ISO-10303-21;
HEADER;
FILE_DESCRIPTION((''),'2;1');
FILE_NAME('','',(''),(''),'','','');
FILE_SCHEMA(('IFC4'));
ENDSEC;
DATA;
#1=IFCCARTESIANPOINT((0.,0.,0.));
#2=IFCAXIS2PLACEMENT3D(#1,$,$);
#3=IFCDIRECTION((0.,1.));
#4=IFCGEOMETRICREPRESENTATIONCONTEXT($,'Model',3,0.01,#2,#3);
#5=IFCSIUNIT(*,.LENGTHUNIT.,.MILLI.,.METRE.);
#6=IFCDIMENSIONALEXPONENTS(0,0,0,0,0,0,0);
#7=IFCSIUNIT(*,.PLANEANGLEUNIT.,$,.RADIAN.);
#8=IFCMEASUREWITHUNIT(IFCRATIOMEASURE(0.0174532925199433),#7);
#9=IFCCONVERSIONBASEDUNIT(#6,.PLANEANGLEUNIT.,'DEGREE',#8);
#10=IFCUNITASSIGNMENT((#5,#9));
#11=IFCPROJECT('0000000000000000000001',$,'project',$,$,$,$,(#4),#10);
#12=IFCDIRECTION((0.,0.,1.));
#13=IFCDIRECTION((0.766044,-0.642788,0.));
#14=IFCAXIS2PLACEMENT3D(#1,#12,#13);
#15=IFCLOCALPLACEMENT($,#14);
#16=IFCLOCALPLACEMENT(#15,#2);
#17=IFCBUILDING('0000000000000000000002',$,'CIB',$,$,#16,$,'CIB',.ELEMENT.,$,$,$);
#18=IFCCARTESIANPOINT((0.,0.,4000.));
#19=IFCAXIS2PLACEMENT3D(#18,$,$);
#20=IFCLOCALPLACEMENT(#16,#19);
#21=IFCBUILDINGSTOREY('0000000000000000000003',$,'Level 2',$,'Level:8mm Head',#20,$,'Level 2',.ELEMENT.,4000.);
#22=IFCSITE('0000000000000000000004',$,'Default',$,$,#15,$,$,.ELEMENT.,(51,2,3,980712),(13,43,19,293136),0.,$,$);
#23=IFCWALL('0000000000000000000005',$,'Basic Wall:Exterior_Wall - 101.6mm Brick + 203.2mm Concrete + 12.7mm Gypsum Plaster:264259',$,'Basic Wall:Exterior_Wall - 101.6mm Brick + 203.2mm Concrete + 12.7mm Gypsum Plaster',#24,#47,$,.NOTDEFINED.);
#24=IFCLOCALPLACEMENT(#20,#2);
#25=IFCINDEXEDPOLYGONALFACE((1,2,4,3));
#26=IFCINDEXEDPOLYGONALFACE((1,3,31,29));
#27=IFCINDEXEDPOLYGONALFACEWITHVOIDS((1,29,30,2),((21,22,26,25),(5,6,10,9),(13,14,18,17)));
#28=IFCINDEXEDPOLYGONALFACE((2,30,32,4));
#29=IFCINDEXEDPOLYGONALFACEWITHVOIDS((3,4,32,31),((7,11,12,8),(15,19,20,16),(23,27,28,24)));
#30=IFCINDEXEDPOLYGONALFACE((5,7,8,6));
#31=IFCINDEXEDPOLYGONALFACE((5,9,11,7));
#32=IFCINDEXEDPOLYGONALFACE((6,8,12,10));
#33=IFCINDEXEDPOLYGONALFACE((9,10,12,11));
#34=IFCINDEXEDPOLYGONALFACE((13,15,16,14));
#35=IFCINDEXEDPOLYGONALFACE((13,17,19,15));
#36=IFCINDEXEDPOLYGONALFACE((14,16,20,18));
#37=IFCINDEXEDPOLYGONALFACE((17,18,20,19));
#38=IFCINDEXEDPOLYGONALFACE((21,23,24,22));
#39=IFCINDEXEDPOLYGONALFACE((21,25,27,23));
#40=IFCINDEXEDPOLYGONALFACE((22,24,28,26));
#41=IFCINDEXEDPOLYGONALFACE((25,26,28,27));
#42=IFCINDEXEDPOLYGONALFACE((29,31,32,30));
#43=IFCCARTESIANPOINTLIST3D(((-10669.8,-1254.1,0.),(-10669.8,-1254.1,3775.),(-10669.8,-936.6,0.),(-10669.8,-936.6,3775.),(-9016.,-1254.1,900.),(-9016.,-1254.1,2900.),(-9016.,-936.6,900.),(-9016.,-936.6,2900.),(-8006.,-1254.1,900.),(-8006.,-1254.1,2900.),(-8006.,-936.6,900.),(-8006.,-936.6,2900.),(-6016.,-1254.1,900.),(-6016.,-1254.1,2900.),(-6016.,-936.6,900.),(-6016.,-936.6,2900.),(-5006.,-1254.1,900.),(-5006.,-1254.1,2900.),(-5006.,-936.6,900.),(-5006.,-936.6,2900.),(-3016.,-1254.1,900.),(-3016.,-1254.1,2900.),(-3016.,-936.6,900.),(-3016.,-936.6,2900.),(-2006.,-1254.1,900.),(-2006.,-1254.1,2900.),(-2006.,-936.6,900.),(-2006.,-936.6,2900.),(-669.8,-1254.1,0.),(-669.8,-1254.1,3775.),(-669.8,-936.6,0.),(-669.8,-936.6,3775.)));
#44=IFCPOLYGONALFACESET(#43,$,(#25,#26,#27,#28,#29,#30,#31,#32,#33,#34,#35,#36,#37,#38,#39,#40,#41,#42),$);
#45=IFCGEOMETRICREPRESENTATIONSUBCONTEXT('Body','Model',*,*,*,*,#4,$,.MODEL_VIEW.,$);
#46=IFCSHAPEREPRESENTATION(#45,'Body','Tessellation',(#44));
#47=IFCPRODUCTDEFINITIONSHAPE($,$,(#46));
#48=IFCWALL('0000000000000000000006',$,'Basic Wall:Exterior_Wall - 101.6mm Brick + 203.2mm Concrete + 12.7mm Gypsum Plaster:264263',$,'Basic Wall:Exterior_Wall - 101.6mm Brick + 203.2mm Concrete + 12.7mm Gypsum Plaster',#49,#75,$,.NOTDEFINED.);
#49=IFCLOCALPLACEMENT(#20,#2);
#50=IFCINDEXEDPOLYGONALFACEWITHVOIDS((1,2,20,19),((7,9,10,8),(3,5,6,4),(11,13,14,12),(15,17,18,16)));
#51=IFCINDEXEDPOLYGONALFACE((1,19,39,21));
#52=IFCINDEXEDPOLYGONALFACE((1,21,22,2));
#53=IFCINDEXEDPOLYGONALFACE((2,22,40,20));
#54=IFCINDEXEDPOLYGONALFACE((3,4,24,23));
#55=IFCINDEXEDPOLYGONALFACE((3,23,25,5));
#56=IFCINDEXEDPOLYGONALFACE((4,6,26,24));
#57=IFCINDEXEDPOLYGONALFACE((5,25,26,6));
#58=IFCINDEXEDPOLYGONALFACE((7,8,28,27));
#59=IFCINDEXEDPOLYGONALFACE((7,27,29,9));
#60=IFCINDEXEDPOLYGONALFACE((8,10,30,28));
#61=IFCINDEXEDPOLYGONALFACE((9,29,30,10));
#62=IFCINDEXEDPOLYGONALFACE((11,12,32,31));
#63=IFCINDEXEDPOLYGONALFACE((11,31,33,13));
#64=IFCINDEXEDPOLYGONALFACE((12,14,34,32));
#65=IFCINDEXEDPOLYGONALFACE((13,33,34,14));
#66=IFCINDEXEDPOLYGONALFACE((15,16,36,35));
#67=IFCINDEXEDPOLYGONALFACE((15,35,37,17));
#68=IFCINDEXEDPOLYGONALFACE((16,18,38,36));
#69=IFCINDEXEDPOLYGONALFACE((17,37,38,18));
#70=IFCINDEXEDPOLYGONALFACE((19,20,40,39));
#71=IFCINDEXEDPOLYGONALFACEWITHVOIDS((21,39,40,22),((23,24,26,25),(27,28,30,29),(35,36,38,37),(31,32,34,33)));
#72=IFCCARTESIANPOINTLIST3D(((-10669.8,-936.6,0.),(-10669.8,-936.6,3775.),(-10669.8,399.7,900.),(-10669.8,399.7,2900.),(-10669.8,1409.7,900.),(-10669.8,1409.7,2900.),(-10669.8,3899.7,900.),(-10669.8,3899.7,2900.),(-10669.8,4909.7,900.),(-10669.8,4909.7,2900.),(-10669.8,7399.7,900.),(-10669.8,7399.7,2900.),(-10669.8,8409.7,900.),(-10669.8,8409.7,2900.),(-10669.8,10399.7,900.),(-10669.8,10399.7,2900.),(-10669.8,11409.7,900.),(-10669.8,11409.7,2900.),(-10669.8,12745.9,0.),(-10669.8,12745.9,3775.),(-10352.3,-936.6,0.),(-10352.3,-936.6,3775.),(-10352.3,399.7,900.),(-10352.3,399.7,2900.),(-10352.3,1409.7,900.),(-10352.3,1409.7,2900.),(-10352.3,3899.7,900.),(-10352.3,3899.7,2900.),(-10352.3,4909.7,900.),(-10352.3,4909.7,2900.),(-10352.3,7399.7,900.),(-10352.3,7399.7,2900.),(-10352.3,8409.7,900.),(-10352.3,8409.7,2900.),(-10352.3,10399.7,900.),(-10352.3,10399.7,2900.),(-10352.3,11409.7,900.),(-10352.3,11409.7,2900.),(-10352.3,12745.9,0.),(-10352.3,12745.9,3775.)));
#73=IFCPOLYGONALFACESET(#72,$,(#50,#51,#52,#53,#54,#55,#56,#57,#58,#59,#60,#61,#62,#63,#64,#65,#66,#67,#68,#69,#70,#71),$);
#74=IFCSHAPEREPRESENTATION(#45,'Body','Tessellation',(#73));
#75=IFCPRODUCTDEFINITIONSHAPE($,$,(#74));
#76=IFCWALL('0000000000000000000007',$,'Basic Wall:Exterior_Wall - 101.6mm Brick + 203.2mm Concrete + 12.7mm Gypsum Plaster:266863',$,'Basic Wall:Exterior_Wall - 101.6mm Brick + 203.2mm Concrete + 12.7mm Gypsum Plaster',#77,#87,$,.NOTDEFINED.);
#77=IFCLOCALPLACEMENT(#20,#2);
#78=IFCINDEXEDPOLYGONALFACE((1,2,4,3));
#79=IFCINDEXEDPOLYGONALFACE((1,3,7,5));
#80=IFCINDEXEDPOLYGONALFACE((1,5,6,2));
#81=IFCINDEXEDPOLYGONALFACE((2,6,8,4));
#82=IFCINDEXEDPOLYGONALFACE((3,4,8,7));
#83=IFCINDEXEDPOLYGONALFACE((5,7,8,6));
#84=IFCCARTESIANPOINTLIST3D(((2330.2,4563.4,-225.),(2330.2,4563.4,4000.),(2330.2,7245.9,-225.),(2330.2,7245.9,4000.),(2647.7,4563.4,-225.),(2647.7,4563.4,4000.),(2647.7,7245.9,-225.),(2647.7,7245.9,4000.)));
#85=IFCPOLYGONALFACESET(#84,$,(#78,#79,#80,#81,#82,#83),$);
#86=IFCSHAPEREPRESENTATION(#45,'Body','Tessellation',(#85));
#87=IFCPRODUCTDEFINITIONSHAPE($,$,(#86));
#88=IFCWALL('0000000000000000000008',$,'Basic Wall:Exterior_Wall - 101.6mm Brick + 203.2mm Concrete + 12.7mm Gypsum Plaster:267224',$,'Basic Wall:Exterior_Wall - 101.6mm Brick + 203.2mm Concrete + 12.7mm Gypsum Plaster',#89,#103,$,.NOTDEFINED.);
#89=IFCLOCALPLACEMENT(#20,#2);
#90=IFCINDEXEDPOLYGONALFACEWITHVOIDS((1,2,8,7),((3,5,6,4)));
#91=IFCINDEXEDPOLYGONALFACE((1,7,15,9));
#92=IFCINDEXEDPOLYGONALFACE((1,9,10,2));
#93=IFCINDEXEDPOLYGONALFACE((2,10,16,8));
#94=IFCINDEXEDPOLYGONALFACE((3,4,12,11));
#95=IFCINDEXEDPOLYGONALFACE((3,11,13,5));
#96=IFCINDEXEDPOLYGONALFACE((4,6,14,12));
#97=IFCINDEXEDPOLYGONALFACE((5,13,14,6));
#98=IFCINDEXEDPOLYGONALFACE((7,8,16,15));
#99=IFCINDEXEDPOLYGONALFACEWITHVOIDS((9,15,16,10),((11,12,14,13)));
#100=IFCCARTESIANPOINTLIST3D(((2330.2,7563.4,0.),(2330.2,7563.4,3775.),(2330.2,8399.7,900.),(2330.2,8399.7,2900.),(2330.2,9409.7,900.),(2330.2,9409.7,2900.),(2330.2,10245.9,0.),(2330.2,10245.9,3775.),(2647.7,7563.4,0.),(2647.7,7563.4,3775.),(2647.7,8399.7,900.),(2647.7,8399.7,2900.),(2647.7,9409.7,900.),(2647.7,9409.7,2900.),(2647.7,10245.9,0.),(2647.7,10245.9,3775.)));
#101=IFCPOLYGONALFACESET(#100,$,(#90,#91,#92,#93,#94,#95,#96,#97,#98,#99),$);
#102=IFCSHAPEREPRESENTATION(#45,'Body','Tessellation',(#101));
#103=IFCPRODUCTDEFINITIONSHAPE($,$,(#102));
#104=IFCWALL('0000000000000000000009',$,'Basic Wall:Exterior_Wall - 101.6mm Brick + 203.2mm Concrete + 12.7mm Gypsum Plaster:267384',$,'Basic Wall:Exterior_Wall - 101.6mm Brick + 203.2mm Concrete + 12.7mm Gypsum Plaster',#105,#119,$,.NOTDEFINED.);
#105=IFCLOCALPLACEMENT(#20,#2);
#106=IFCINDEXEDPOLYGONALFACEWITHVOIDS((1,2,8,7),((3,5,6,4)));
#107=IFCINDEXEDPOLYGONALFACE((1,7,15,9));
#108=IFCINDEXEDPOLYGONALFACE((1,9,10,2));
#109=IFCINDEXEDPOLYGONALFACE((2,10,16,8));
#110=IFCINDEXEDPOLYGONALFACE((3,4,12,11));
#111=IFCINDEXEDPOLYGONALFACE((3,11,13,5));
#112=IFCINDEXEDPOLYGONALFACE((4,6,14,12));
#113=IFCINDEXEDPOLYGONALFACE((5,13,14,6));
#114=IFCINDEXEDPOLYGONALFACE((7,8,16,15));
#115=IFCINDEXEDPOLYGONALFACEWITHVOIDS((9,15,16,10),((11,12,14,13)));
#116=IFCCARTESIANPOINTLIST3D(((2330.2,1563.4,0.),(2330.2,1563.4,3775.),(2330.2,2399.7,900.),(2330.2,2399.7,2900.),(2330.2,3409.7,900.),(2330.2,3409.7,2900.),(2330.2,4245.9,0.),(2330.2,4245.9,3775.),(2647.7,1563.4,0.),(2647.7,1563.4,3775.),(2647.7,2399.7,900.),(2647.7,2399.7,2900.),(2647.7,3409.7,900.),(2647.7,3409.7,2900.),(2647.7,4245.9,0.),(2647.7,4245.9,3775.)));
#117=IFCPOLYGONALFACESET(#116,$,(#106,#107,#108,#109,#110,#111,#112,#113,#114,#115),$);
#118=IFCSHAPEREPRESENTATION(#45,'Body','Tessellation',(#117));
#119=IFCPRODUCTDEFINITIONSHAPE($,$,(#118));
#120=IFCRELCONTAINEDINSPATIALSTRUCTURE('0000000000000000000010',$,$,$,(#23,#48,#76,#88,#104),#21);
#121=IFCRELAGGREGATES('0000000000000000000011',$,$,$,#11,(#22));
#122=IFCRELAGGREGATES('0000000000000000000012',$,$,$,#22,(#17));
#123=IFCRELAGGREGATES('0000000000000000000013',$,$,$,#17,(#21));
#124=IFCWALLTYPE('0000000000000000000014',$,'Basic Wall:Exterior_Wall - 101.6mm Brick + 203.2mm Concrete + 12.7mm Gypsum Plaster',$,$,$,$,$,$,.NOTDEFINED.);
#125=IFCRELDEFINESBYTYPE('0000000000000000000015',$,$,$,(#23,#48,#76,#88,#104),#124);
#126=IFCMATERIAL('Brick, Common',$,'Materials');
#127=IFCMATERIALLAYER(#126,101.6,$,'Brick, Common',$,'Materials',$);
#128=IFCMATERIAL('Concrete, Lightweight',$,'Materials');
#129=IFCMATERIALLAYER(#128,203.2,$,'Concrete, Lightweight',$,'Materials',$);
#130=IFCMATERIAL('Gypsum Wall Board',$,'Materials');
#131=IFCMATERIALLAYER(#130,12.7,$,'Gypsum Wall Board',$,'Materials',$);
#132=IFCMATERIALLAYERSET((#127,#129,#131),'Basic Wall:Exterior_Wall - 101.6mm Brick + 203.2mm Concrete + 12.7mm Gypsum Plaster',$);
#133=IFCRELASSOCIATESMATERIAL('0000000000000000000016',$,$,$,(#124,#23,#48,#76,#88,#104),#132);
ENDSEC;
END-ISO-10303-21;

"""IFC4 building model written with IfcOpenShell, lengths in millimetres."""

from ifc_helpers import new_model, entity, si_unit, converted_unit, direction, frame, frame_2d, origin, place, context, subcontext, project, spatial, polyline, rectangle, extrude, clip, bounded_halfspace, material, layer, layer_set, layer_usage, type_object, element, save


model = new_model("IFC4")

# Units and contexts
model_context = context("Model", 3, precision=0.01, world=origin(), true_north=direction((0.0, 1.0)))
body_context = subcontext(model_context, "Body", "Model", "MODEL_VIEW")
ifc_project = project(units=[si_unit("LENGTHUNIT", "METRE", prefix="MILLI"), converted_unit("PLANEANGLEUNIT", "DEGREE", entity("IfcRatioMeasure", 0.0174532925199433), si_unit("PLANEANGLEUNIT", "RADIAN"), dimensions=[0, 0, 0, 0, 0, 0, 0])], contexts=[model_context])

# Site, building, storey
site_placement = place(None, frame((0.0, 0.0, 0.0), z_axis=(0.0, 0.0, 1.0), x_axis=(0.766044, -0.642788, 0.0)))
site = spatial("IfcSite", under=ifc_project, at=site_placement, Name="Default", CompositionType="ELEMENT", RefLatitude=(51, 2, 3, 980712), RefLongitude=(13, 43, 19, 293136), RefElevation=0.0)
building_placement = place(site_placement, origin())
building = spatial("IfcBuilding", under=site, at=building_placement, Name="CIB", LongName="CIB", CompositionType="ELEMENT")
storey_placement = place(building_placement, frame((0.0, 0.0, 4000.0)))
storey = spatial("IfcBuildingStorey", under=building, at=storey_placement, Name="Level 2", ObjectType="Level:8mm Head", LongName="Level 2", CompositionType="ELEMENT", Elevation=4000.0)

# Shared definitions
ifc_material_1 = material(Name="Brick, Common", Category="Materials")
ifc_layer_1 = layer(ifc_material_1, 101.6, Name="Brick, Common", Category="Materials")
ifc_material_2 = material(Name="Concrete, Lightweight", Category="Materials")
ifc_layer_2 = layer(ifc_material_2, 203.2, Name="Concrete, Lightweight", Category="Materials")
ifc_material_3 = material(Name="Gypsum Wall Board", Category="Materials")
ifc_layer_3 = layer(ifc_material_3, 12.7, Name="Gypsum Wall Board", Category="Materials")
ifc_layer_set_1 = layer_set([ifc_layer_1, ifc_layer_2, ifc_layer_3], Name="Basic Wall:Exterior_Wall - 101.6mm Brick + 203.2mm Concrete + 12.7mm Gypsum Plaster")
wall_type_1 = type_object("IfcWallType", Name="Basic Wall:Exterior_Wall - 101.6mm Brick + 203.2mm Concrete + 12.7mm Gypsum Plaster", PredefinedType="NOTDEFINED", material=ifc_layer_set_1)

# Walls, openings
ifc_layer_usage_1 = layer_usage(ifc_layer_set_1, "AXIS2", "NEGATIVE", 158.8)
wall_1_placement = place(storey_placement, frame((-669.8, -1095.3, 0.0), z_axis=(0.0, 0.0, 1.0), x_axis=(-1.0, 0.0, 0.0)))
wall_1 = element("IfcWall", 1, at=wall_1_placement, inside=storey, type_object=wall_type_1, material=ifc_layer_usage_1, Name="Basic Wall:Exterior_Wall - 101.6mm Brick + 203.2mm Concrete + 12.7mm Gypsum Plaster:264259", ObjectType="Basic Wall:Exterior_Wall - 101.6mm Brick + 203.2mm Concrete + 12.7mm Gypsum Plaster", PredefinedType="NOTDEFINED", context=body_context, shape_type="Clipping", body=[
    clip(extrude(rectangle(XDim=10000.0, YDim=317.5, at=frame_2d((5000.0, 0.0), x_axis=(-1.0, 0.0))), origin(), (0.0, 0.0, 1.0), 3775.0), bounded_halfspace(frame((0.0, -158.8, 3775.0), z_axis=(0.0, 0.0, -1.0), x_axis=(0.0, -1.0, 0.0)), True, frame((0.0, -158.8, 3775.0)), polyline([(0.0, 0.0), (9682.5, 0.0), (10000.0, 0.0), (10000.0, 317.5), (0.0, 317.5), (0.0, 0.0)]))),
])
opening_1_placement = place(wall_1_placement, frame((2346.2, 158.7, 900.0)))
element("IfcOpeningElement", 2, at=opening_1_placement, cuts=wall_1, ObjectType="Opening", PredefinedType="OPENING", context=body_context, shape_type="SweptSolid", body=[
    extrude(rectangle(XDim=2000.0, YDim=1010.0, at=frame_2d((1000.0, 505.0), x_axis=(1.0, 0.0))), frame((0.0, 0.0, 0.0), z_axis=(0.0, -1.0, 0.0), x_axis=(0.0, 0.0, 1.0)), (0.0, 0.0, 1.0), 317.5),
])
opening_2_placement = place(wall_1_placement, frame((8346.2, 158.7, 900.0)))
element("IfcOpeningElement", 3, at=opening_2_placement, cuts=wall_1, ObjectType="Opening", PredefinedType="OPENING", context=body_context, shape_type="SweptSolid", body=[
    extrude(rectangle(XDim=2000.0, YDim=1010.0, at=frame_2d((1000.0, 505.0), x_axis=(1.0, 0.0))), frame((0.0, 0.0, 0.0), z_axis=(0.0, -1.0, 0.0), x_axis=(0.0, 0.0, 1.0)), (0.0, 0.0, 1.0), 317.5),
])
opening_3_placement = place(wall_1_placement, frame((5346.2, 158.7, 900.0)))
element("IfcOpeningElement", 4, at=opening_3_placement, cuts=wall_1, ObjectType="Opening", PredefinedType="OPENING", context=body_context, shape_type="SweptSolid", body=[
    extrude(rectangle(XDim=2000.0, YDim=1010.0, at=frame_2d((1000.0, 505.0), x_axis=(1.0, 0.0))), frame((0.0, 0.0, 0.0), z_axis=(0.0, -1.0, 0.0), x_axis=(0.0, 0.0, 1.0)), (0.0, 0.0, 1.0), 317.5),
])
ifc_layer_usage_2 = layer_usage(ifc_layer_set_1, "AXIS2", "NEGATIVE", 158.8)
wall_2_placement = place(storey_placement, frame((-10511.0, -936.6, 0.0), z_axis=(0.0, 0.0, 1.0), x_axis=(0.0, 1.0, 0.0)))
wall_2 = element("IfcWall", 5, at=wall_2_placement, inside=storey, type_object=wall_type_1, material=ifc_layer_usage_2, Name="Basic Wall:Exterior_Wall - 101.6mm Brick + 203.2mm Concrete + 12.7mm Gypsum Plaster:264263", ObjectType="Basic Wall:Exterior_Wall - 101.6mm Brick + 203.2mm Concrete + 12.7mm Gypsum Plaster", PredefinedType="NOTDEFINED", context=body_context, shape_type="Clipping", body=[
    clip(extrude(rectangle(XDim=13682.5, YDim=317.5, at=frame_2d((6841.2, 0.0), x_axis=(-1.0, 0.0))), origin(), (0.0, 0.0, 1.0), 3775.0), bounded_halfspace(frame((0.0, -158.7, 3775.0), z_axis=(0.0, 0.0, -1.0), x_axis=(1.0, 0.0, 0.0)), True, frame((0.0, -158.7, 3775.0)), polyline([(0.0, 0.0), (13682.5, 0.0), (13682.5, 317.5), (0.0, 317.5), (0.0, 0.0)]))),
])
opening_4_placement = place(wall_2_placement, frame((2346.2, 158.8, 900.0)))
element("IfcOpeningElement", 6, at=opening_4_placement, cuts=wall_2, ObjectType="Opening", PredefinedType="OPENING", context=body_context, shape_type="SweptSolid", body=[
    extrude(rectangle(XDim=2000.0, YDim=1010.0, at=frame_2d((1000.0, 505.0), x_axis=(1.0, 0.0))), frame((0.0, 0.0, 0.0), z_axis=(0.0, -1.0, 0.0), x_axis=(0.0, 0.0, 1.0)), (0.0, 0.0, 1.0), 317.5),
])
opening_5_placement = place(wall_2_placement, frame((12346.2, 158.8, 900.0)))
element("IfcOpeningElement", 7, at=opening_5_placement, cuts=wall_2, ObjectType="Opening", PredefinedType="OPENING", context=body_context, shape_type="SweptSolid", body=[
    extrude(rectangle(XDim=2000.0, YDim=1010.0, at=frame_2d((1000.0, 505.0), x_axis=(1.0, 0.0))), frame((0.0, 0.0, 0.0), z_axis=(0.0, -1.0, 0.0), x_axis=(0.0, 0.0, 1.0)), (0.0, 0.0, 1.0), 317.5),
])
opening_6_placement = place(wall_2_placement, frame((9346.2, 158.8, 900.0)))
element("IfcOpeningElement", 8, at=opening_6_placement, cuts=wall_2, ObjectType="Opening", PredefinedType="OPENING", context=body_context, shape_type="SweptSolid", body=[
    extrude(rectangle(XDim=2000.0, YDim=1010.0, at=frame_2d((1000.0, 505.0), x_axis=(1.0, 0.0))), frame((0.0, 0.0, 0.0), z_axis=(0.0, -1.0, 0.0), x_axis=(0.0, 0.0, 1.0)), (0.0, 0.0, 1.0), 317.5),
])
opening_7_placement = place(wall_2_placement, frame((5846.2, 158.8, 900.0)))
element("IfcOpeningElement", 9, at=opening_7_placement, cuts=wall_2, ObjectType="Opening", PredefinedType="OPENING", context=body_context, shape_type="SweptSolid", body=[
    extrude(rectangle(XDim=2000.0, YDim=1010.0, at=frame_2d((1000.0, 505.0), x_axis=(1.0, 0.0))), frame((0.0, 0.0, 0.0), z_axis=(0.0, -1.0, 0.0), x_axis=(0.0, 0.0, 1.0)), (0.0, 0.0, 1.0), 317.5),
])

# Wall
ifc_layer_usage_3 = layer_usage(ifc_layer_set_1, "AXIS2", "NEGATIVE", 158.8)
wall_3_placement = place(storey_placement, frame((2489.0, 7245.9, -225.0), z_axis=(0.0, 0.0, 1.0), x_axis=(0.0, -1.0, 0.0)))
element("IfcWall", 10, at=wall_3_placement, inside=storey, type_object=wall_type_1, material=ifc_layer_usage_3, Name="Basic Wall:Exterior_Wall - 101.6mm Brick + 203.2mm Concrete + 12.7mm Gypsum Plaster:266863", ObjectType="Basic Wall:Exterior_Wall - 101.6mm Brick + 203.2mm Concrete + 12.7mm Gypsum Plaster", PredefinedType="NOTDEFINED", context=body_context, shape_type="SweptSolid", body=[
    extrude(rectangle(XDim=2682.5, YDim=317.5, at=frame_2d((1341.2, 0.0), x_axis=(-1.0, 0.0))), origin(), (0.0, 0.0, 1.0), 4225.0),
])

# Walls, openings
ifc_layer_usage_4 = layer_usage(ifc_layer_set_1, "AXIS2", "NEGATIVE", 158.8)
wall_4_placement = place(storey_placement, frame((2489.0, 10245.9, 0.0), z_axis=(0.0, 0.0, 1.0), x_axis=(0.0, -1.0, 0.0)))
wall_4 = element("IfcWall", 11, at=wall_4_placement, inside=storey, type_object=wall_type_1, material=ifc_layer_usage_4, Name="Basic Wall:Exterior_Wall - 101.6mm Brick + 203.2mm Concrete + 12.7mm Gypsum Plaster:267224", ObjectType="Basic Wall:Exterior_Wall - 101.6mm Brick + 203.2mm Concrete + 12.7mm Gypsum Plaster", PredefinedType="NOTDEFINED", context=body_context, shape_type="Clipping", body=[
    clip(extrude(rectangle(XDim=2682.5, YDim=317.5, at=frame_2d((1341.2, 0.0), x_axis=(-1.0, 0.0))), origin(), (0.0, 0.0, 1.0), 3775.0), bounded_halfspace(frame((0.0, -158.8, 3775.0), z_axis=(0.0, 0.0, -1.0), x_axis=(-1.0, 0.0, 0.0)), True, frame((0.0, -158.8, 3775.0)), polyline([(0.0, 0.0), (2682.5, 0.0), (2682.5, 317.5), (0.0, 317.5), (0.0, 0.0)]))),
])
opening_8_placement = place(wall_4_placement, frame((1846.2, 158.8, 900.0)))
element("IfcOpeningElement", 12, at=opening_8_placement, cuts=wall_4, ObjectType="Opening", PredefinedType="OPENING", context=body_context, shape_type="SweptSolid", body=[
    extrude(rectangle(XDim=2000.0, YDim=1010.0, at=frame_2d((1000.0, 505.0), x_axis=(1.0, 0.0))), frame((0.0, 0.0, 0.0), z_axis=(0.0, -1.0, 0.0), x_axis=(0.0, 0.0, 1.0)), (0.0, 0.0, 1.0), 317.5),
])
ifc_layer_usage_5 = layer_usage(ifc_layer_set_1, "AXIS2", "POSITIVE", -158.8)
wall_5_placement = place(storey_placement, frame((2489.0, 1563.4, 0.0), z_axis=(0.0, 0.0, 1.0), x_axis=(0.0, 1.0, 0.0)))
wall_5 = element("IfcWall", 13, at=wall_5_placement, inside=storey, type_object=wall_type_1, material=ifc_layer_usage_5, Name="Basic Wall:Exterior_Wall - 101.6mm Brick + 203.2mm Concrete + 12.7mm Gypsum Plaster:267384", ObjectType="Basic Wall:Exterior_Wall - 101.6mm Brick + 203.2mm Concrete + 12.7mm Gypsum Plaster", PredefinedType="NOTDEFINED", context=body_context, shape_type="Clipping", body=[
    clip(extrude(rectangle(XDim=2682.5, YDim=317.5, at=frame_2d((1341.2, 0.0), x_axis=(-1.0, 0.0))), origin(), (0.0, 0.0, 1.0), 3775.0), bounded_halfspace(frame((0.0, -158.8, 3775.0), z_axis=(0.0, 0.0, -1.0), x_axis=(1.0, 0.0, 0.0)), True, frame((0.0, -158.8, 3775.0)), polyline([(0.0, 0.0), (2682.5, 0.0), (2682.5, 317.5), (0.0, 317.5), (0.0, 0.0)]))),
])
opening_9_placement = place(wall_5_placement, frame((836.3, -158.7, 900.0)))
element("IfcOpeningElement", 14, at=opening_9_placement, cuts=wall_5, ObjectType="Opening", PredefinedType="OPENING", context=body_context, shape_type="SweptSolid", body=[
    extrude(rectangle(XDim=2000.0, YDim=1010.0, at=frame_2d((1000.0, 505.0), x_axis=(1.0, 0.0))), frame((0.0, 0.0, 0.0), z_axis=(0.0, 1.0, 0.0), x_axis=(0.0, 0.0, 1.0)), (0.0, 0.0, 1.0), 317.5),
])

save(model, "model.ifc")
